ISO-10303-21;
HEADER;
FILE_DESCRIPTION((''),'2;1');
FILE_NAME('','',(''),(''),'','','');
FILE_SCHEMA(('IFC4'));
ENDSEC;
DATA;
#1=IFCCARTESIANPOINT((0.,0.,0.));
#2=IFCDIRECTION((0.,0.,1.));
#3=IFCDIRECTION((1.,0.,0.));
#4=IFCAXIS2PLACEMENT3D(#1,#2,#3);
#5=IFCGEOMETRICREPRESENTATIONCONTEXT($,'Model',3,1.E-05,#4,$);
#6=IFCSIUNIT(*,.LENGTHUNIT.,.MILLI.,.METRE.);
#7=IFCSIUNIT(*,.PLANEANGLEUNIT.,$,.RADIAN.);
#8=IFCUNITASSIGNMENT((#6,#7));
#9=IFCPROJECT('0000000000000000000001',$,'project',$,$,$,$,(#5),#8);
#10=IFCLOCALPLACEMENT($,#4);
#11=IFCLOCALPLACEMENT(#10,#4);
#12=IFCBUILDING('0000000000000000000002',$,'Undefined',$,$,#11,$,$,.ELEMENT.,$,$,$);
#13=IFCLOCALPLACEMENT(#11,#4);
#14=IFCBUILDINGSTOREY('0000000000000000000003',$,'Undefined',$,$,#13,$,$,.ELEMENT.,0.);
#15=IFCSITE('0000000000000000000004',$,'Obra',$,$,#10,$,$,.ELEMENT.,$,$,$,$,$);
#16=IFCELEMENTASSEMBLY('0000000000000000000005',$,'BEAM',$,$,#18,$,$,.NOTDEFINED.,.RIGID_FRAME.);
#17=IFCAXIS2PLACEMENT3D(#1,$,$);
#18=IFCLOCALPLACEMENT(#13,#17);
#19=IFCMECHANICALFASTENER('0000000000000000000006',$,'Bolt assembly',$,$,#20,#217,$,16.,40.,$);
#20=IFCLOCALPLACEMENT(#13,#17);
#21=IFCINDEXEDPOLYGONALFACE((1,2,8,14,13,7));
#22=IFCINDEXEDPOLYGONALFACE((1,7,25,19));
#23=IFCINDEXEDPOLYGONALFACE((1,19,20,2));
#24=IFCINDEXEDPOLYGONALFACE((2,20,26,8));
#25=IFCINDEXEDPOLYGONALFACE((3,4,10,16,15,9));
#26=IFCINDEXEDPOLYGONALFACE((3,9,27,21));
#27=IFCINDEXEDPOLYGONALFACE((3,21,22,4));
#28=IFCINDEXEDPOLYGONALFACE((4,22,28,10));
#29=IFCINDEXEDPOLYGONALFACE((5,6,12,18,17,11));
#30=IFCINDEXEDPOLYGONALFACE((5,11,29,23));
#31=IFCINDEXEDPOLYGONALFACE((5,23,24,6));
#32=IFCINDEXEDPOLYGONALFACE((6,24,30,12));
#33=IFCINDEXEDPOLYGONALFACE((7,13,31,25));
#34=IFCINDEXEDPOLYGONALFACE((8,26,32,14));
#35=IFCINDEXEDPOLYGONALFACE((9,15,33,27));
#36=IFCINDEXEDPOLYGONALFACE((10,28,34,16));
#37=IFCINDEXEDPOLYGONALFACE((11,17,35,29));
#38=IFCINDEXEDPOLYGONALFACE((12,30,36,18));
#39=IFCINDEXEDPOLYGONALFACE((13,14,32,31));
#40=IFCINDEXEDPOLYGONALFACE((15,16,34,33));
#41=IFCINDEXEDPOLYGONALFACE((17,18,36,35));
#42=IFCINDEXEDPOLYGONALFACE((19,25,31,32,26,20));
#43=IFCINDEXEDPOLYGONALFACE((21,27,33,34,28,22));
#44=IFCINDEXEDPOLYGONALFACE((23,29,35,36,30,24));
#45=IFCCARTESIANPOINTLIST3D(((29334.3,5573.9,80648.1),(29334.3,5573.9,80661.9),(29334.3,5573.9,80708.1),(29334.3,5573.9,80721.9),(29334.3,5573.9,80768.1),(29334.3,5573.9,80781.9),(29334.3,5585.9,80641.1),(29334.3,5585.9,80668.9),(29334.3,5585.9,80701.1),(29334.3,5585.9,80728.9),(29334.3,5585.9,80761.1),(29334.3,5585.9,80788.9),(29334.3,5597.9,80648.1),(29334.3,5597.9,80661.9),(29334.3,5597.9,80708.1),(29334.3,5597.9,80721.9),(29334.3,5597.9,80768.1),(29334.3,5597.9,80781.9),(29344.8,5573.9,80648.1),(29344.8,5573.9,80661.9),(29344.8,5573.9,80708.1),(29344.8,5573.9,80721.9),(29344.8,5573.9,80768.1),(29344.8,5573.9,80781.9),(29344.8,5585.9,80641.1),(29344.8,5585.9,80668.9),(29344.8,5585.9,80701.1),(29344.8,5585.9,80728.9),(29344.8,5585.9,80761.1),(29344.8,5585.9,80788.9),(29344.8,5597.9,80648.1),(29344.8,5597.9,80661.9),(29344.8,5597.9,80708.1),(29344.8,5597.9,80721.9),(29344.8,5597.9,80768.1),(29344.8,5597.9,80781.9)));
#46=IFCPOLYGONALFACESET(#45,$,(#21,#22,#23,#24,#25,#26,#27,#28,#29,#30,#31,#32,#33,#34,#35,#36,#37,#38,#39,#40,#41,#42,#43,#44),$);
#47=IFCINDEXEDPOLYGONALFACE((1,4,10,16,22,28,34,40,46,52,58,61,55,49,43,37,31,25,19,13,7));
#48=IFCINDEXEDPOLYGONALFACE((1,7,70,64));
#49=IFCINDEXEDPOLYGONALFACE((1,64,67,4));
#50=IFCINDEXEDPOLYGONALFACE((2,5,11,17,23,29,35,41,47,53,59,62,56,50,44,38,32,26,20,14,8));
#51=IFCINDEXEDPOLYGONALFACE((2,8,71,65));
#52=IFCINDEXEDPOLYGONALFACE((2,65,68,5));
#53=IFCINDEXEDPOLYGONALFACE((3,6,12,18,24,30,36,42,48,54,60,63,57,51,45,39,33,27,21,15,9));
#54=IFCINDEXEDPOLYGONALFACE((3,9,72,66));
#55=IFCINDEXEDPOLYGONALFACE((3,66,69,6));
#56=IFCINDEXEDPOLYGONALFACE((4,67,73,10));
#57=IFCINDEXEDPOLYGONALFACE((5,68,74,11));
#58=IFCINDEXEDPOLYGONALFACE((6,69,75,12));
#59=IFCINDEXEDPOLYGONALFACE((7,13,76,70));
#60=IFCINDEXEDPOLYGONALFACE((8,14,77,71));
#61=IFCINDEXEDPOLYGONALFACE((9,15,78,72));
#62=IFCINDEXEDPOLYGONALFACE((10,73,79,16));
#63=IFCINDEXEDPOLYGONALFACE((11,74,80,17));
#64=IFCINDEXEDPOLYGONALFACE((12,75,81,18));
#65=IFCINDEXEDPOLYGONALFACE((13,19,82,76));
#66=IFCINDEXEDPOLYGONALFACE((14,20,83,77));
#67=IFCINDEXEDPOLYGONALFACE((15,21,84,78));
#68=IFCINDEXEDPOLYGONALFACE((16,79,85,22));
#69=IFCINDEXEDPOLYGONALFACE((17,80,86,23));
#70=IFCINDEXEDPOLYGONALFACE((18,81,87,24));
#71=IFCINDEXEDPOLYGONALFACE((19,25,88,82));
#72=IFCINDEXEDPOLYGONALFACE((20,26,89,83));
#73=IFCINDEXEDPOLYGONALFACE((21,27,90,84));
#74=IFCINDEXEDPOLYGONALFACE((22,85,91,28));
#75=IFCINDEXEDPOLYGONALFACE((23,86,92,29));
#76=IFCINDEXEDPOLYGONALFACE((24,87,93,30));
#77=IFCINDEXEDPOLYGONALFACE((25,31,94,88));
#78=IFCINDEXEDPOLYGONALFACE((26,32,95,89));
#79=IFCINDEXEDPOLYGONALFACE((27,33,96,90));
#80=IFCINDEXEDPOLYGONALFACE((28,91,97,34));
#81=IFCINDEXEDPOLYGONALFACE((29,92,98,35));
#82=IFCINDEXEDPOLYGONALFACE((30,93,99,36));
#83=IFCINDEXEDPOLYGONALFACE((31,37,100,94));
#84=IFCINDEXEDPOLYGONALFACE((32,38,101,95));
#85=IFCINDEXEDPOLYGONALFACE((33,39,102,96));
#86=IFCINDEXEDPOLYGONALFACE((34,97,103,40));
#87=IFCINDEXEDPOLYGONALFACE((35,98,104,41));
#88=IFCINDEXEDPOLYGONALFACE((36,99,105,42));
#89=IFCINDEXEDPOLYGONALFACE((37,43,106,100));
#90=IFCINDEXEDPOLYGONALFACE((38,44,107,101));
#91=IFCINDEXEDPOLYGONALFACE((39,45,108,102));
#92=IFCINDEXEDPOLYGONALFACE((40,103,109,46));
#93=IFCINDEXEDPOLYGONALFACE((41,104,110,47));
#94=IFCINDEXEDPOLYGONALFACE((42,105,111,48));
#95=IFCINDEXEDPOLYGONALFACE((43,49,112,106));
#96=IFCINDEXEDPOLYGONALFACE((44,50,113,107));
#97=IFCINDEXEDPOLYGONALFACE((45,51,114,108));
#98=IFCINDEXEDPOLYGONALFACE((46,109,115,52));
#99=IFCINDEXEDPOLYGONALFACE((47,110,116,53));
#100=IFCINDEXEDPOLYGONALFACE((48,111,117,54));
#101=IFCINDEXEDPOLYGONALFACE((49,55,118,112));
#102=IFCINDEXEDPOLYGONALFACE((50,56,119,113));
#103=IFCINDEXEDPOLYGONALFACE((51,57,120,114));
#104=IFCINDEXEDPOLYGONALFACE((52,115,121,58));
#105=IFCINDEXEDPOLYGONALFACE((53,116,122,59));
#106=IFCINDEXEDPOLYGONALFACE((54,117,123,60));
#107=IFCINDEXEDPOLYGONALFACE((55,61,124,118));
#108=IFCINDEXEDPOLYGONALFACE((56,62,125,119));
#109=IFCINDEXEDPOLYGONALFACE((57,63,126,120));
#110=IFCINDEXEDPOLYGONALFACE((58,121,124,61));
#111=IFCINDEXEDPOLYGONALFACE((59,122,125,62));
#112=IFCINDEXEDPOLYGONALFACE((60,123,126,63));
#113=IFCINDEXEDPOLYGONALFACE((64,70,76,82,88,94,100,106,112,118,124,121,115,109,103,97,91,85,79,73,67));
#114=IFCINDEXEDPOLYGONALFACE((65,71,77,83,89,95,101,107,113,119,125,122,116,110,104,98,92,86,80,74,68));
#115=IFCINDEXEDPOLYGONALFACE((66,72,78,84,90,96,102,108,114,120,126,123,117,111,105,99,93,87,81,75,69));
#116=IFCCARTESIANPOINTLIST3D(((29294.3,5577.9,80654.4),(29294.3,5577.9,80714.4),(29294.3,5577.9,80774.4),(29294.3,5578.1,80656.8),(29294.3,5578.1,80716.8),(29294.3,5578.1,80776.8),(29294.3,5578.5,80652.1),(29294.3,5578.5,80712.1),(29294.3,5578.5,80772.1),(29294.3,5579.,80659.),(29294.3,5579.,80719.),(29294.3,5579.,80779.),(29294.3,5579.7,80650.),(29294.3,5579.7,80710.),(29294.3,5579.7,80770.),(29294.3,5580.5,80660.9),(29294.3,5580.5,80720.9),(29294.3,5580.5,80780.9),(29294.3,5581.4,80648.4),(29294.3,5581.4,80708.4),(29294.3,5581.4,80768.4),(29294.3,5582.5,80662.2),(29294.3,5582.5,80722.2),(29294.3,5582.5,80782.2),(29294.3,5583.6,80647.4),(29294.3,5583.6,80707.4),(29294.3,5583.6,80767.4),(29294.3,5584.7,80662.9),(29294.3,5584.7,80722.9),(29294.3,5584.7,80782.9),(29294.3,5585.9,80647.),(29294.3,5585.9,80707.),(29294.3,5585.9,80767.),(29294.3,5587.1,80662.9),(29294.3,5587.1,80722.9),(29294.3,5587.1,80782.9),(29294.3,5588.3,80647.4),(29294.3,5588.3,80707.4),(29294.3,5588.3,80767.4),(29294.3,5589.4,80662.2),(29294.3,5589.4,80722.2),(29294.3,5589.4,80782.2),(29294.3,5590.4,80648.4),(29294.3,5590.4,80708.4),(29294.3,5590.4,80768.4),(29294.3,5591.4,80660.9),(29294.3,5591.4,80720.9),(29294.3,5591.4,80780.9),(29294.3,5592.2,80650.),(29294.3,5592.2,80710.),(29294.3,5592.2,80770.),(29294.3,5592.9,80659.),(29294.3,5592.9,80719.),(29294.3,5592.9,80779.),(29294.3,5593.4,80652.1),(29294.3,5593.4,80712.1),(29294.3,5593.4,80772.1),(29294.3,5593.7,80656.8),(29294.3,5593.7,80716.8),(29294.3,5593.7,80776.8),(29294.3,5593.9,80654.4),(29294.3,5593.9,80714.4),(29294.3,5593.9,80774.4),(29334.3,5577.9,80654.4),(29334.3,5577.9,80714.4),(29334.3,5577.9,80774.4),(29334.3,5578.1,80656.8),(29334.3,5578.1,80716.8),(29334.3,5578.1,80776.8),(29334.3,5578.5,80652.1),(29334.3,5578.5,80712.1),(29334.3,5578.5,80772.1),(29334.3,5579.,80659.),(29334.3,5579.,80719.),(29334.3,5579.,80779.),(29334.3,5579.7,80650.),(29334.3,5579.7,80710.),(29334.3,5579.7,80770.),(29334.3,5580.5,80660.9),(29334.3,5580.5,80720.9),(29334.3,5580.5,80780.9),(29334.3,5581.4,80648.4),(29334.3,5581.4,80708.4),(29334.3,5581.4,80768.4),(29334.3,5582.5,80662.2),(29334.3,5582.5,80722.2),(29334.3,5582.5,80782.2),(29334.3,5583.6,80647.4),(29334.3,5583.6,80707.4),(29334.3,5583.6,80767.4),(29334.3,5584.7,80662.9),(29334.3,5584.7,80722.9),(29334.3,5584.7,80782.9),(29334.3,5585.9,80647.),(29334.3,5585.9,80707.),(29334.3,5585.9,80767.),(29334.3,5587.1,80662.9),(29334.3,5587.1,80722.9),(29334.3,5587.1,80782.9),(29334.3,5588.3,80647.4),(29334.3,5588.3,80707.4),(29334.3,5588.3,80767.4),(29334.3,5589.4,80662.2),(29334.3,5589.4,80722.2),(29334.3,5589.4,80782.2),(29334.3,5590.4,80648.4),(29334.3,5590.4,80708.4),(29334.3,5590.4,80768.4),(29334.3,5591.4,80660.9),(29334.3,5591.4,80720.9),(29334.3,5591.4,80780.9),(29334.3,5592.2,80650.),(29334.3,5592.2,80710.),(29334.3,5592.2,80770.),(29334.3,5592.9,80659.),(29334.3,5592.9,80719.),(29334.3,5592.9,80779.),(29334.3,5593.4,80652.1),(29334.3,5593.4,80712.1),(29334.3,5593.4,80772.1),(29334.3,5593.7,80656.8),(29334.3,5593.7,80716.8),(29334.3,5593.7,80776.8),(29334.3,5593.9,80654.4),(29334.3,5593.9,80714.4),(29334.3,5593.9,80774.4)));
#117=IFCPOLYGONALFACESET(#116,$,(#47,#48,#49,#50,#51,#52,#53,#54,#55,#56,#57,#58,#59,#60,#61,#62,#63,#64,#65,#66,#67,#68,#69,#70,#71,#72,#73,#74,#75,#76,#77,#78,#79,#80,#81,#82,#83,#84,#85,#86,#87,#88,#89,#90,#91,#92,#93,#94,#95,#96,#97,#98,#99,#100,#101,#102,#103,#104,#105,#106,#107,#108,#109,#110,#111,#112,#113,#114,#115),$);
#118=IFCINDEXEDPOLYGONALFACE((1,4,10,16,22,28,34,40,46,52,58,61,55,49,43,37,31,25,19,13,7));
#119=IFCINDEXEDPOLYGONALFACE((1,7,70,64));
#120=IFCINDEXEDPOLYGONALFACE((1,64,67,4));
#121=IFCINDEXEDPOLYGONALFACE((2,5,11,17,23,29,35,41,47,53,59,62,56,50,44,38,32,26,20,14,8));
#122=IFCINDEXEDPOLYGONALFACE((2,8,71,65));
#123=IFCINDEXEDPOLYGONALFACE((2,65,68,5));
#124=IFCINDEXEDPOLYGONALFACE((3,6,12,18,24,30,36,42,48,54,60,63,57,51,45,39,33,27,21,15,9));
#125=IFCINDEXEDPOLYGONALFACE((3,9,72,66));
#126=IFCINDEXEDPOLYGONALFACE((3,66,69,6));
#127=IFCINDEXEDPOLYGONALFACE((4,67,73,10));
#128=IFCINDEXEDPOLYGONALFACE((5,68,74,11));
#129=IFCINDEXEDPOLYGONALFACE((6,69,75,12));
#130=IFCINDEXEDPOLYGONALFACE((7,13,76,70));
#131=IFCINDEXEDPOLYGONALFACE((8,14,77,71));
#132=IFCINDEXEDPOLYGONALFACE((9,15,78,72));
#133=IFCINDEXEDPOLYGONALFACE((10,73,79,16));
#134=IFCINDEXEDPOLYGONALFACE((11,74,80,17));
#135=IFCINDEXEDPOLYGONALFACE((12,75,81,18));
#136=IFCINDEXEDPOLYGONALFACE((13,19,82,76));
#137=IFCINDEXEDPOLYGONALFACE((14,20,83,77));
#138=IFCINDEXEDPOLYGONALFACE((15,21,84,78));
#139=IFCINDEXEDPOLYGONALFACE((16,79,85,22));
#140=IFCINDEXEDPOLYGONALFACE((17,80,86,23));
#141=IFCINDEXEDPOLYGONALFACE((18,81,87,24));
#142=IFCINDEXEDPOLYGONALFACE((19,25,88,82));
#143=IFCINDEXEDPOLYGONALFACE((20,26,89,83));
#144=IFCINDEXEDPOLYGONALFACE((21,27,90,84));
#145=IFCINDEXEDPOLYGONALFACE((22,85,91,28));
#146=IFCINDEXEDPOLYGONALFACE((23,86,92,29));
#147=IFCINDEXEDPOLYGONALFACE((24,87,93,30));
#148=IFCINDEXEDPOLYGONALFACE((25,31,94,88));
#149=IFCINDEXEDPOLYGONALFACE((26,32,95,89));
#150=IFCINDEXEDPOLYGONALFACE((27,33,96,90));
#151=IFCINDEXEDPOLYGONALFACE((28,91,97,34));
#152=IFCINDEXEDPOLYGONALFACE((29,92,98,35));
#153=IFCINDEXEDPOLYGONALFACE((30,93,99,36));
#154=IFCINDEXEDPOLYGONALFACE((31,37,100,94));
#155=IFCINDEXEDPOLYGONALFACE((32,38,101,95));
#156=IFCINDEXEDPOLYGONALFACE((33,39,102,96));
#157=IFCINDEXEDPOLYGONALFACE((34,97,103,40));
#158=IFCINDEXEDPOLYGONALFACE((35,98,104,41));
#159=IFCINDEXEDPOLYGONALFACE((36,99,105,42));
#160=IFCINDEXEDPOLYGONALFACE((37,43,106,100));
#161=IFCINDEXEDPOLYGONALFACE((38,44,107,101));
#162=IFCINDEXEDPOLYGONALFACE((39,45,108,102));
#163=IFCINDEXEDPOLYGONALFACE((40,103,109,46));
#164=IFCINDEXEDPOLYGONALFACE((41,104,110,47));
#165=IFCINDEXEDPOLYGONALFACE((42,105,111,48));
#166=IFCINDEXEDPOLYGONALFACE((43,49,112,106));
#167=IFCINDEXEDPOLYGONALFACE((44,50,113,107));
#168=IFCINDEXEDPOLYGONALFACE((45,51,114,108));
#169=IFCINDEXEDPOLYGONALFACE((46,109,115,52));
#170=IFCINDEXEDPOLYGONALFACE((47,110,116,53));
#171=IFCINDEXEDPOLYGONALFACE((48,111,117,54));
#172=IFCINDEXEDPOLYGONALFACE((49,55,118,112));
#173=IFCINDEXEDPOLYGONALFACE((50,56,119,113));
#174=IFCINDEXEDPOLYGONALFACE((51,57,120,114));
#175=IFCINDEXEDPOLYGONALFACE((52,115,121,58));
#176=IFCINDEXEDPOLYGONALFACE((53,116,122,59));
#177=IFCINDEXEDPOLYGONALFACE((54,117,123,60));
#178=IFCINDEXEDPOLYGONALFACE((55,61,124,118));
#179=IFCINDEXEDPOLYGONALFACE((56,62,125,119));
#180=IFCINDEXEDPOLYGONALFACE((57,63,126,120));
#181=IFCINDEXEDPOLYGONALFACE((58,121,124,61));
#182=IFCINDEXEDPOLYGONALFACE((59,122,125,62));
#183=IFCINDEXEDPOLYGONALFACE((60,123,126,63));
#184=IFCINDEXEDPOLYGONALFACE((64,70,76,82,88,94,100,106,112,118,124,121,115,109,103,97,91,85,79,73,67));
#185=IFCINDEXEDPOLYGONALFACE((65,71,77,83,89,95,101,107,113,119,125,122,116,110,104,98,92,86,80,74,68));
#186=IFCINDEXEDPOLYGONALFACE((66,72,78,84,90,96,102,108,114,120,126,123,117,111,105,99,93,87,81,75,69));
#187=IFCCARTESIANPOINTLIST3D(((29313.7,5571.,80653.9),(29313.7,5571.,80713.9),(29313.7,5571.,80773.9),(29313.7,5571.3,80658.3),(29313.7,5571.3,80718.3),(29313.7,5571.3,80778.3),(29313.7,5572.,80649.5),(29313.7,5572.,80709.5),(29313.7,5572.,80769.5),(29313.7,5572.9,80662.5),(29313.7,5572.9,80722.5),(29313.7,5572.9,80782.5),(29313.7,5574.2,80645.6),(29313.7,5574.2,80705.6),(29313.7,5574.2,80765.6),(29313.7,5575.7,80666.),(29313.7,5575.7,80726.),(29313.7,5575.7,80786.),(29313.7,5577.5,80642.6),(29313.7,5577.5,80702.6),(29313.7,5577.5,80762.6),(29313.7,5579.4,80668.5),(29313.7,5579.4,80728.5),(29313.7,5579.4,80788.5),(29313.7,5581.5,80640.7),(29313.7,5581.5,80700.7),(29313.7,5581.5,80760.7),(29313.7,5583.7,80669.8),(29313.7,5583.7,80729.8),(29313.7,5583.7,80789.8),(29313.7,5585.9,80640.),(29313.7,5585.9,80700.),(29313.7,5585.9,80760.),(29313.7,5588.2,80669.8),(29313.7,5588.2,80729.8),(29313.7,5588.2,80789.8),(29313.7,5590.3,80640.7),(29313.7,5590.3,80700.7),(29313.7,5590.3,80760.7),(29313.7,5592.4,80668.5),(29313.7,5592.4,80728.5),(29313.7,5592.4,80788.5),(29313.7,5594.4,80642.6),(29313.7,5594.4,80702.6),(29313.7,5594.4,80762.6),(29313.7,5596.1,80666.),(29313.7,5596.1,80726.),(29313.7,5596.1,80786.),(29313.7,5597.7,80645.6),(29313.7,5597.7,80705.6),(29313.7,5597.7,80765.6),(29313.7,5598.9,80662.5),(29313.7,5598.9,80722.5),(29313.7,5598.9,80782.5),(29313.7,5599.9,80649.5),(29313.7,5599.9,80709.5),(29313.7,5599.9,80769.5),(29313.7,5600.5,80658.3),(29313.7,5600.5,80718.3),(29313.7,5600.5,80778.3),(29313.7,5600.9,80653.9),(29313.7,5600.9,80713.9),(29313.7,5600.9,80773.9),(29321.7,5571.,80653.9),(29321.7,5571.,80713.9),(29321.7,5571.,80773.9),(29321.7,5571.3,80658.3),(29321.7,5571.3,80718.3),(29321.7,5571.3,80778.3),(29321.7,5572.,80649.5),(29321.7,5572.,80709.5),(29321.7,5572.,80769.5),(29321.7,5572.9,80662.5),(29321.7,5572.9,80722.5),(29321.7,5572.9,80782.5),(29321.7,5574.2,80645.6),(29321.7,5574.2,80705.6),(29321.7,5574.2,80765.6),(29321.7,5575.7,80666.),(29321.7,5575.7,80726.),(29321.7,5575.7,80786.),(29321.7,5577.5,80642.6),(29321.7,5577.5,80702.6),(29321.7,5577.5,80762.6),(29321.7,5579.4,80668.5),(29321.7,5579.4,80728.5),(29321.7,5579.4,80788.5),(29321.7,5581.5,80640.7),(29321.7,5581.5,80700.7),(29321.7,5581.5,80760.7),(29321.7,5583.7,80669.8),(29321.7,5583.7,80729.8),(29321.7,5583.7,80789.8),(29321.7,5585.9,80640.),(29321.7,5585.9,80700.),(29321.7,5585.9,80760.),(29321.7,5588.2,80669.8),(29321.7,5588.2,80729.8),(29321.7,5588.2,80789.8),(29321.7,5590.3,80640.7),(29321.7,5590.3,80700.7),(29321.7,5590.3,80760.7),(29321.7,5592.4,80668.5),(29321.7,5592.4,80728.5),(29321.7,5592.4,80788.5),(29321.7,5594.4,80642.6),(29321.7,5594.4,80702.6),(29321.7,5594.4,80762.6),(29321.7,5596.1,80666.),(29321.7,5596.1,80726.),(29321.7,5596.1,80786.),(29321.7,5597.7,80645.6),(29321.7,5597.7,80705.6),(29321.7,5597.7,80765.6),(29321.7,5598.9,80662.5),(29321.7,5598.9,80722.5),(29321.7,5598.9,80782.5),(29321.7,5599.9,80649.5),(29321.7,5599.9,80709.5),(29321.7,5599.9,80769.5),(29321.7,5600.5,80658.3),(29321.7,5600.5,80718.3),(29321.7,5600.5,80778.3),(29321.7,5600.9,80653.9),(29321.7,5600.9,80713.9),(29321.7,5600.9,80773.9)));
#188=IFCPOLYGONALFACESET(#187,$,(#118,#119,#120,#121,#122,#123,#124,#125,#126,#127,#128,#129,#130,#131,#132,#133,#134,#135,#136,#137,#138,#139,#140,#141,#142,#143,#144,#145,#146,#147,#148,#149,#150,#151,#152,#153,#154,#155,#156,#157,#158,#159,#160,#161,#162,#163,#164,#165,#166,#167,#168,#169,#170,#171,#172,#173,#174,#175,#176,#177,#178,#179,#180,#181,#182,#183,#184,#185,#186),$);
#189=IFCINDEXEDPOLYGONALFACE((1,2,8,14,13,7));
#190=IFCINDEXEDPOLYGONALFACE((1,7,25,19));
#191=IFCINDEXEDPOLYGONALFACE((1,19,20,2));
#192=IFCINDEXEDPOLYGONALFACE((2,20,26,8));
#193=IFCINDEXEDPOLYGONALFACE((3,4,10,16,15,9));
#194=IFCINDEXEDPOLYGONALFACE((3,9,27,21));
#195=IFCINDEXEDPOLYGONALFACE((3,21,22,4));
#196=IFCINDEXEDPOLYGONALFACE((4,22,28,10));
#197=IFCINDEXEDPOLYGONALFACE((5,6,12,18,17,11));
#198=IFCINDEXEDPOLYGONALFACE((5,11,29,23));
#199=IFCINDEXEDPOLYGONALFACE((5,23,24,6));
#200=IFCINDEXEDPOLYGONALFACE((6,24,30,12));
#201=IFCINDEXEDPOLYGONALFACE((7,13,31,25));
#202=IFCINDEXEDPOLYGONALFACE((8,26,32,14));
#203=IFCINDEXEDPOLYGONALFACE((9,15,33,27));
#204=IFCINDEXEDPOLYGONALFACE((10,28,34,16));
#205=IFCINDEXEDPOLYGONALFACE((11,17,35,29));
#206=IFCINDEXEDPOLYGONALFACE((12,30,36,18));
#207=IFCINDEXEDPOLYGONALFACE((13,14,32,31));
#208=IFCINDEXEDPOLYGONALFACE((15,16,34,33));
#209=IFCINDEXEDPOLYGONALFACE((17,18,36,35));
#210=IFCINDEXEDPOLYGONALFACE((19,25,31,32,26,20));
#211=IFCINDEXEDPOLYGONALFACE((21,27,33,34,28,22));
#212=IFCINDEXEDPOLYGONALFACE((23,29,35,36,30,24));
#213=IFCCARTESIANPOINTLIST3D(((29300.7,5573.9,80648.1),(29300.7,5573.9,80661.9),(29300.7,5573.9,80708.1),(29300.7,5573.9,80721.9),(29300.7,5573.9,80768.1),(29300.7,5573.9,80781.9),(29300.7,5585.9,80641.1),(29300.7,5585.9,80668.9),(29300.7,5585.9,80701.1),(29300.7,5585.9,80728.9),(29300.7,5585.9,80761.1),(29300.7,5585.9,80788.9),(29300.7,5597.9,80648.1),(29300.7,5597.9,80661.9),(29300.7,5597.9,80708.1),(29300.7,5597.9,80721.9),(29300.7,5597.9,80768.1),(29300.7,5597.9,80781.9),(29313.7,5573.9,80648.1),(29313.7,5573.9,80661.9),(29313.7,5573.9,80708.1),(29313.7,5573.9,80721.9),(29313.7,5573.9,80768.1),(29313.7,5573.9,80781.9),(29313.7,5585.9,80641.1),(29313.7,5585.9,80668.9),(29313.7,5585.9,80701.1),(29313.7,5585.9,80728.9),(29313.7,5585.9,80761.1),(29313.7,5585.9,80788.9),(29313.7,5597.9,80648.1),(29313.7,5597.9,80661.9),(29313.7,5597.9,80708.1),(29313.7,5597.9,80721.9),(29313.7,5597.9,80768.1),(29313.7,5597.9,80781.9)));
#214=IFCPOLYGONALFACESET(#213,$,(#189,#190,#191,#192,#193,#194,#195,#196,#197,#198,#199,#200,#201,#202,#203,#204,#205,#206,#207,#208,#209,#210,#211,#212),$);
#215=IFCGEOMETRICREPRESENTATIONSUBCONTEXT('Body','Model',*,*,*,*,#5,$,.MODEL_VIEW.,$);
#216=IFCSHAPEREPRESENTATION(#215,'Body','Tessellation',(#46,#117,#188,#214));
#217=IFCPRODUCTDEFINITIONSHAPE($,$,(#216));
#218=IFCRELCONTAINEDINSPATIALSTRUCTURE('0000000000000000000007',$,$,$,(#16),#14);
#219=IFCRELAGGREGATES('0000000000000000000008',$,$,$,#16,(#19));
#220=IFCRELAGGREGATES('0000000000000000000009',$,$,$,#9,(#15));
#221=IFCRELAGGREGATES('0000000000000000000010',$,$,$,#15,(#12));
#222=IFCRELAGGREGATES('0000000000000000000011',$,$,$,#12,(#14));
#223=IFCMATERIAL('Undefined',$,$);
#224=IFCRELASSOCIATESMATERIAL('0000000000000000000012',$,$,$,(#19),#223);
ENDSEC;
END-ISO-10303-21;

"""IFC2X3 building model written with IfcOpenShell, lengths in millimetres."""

from ifc_helpers import new_model, si_unit, frame, origin_with_axes, origin_2d_with_axis, place, context, subcontext, project, spatial, polyline, circle, outline, extrude, source, transform, mapped, material, element, aggregate, save


model = new_model("IFC2X3")

# Units and contexts
model_context = context("Model", 3, precision=1e-05, world=origin_with_axes())
body_context = subcontext(model_context, "Body", "Model", "MODEL_VIEW")
ifc_project = project(units=[si_unit("LENGTHUNIT", "METRE", prefix="MILLI"), si_unit("PLANEANGLEUNIT", "RADIAN")], contexts=[model_context])

# Site, building, storey
site_placement = place(None, origin_with_axes())
site = spatial("IfcSite", under=ifc_project, at=site_placement, Name="Obra", CompositionType="ELEMENT")
building_placement = place(site_placement, origin_with_axes())
building = spatial("IfcBuilding", under=site, at=building_placement, Name="Undefined", CompositionType="ELEMENT")
storey_placement = place(building_placement, origin_with_axes())
storey = spatial("IfcBuildingStorey", under=building, at=storey_placement, Name="Undefined", CompositionType="ELEMENT", Elevation=0.0)

# Shared definitions
ifc_material_1 = material(Name="Undefined")

# Element assembly, mechanical fastener
shared_shape_1 = source(origin_with_axes(), body_context, "Body", "SweptSolid", [
    extrude(outline(polyline([(13.9, 0.0), (6.9, 12.0), (-6.9, 12.0), (-13.9, 0.0), (-6.9, -12.0), (6.9, -12.0), (13.9, 0.0)])), frame((0.0, -19.9, 0.0), z_axis=(0.0, 1.0, 0.0), x_axis=(1.0, 0.0, 0.0)), (0.0, 0.0, 1.0), 10.6),
    extrude(circle(Radius=8.0, at=origin_2d_with_axis()), frame((0.0, -9.3, 0.0), z_axis=(0.0, 1.0, 0.0), x_axis=(1.0, 0.0, 0.0)), (0.0, 0.0, 1.0), 40.0),
    extrude(circle(Radius=15.0, at=origin_2d_with_axis()), frame((0.0, 3.3, 0.0), z_axis=(0.0, 1.0, 0.0), x_axis=(1.0, 0.0, 0.0)), (0.0, 0.0, 1.0), 8.0),
    extrude(outline(polyline([(13.9, 0.0), (6.9, 12.0), (-6.9, 12.0), (-13.9, 0.0), (-6.9, -12.0), (6.9, -12.0), (13.9, 0.0)])), frame((0.0, 11.3, 0.0), z_axis=(0.0, 1.0, 0.0), x_axis=(1.0, 0.0, 0.0)), (0.0, 0.0, 1.0), 13.0),
])
assembly_1_placement = place(storey_placement, origin_with_axes())
assembly_1 = element("IfcElementAssembly", 1, at=assembly_1_placement, inside=storey, Name="BEAM", AssemblyPlace="NOTDEFINED", PredefinedType="RIGID_FRAME")
mechanical_fastener_1_placement = place(assembly_1_placement, frame((29325.0, 5535.9, 80850.0), z_axis=(-0.000001, 1.0, 0.0), x_axis=(0.0, 0.0, -1.0)))
mechanical_fastener_1 = element("IfcMechanicalFastener", 2, at=mechanical_fastener_1_placement, material=ifc_material_1, Name="Bolt assembly", NominalDiameter=16.0, NominalLength=40.0, context=body_context, shape_type="MappedRepresentation", body=[
    mapped(shared_shape_1, transform((75.0, 0.0, 50.0))),
    mapped(shared_shape_1, transform((135.0, 0.0, 50.0))),
    mapped(shared_shape_1, transform((195.0, 0.0, 50.0))),
])
aggregate(assembly_1, [mechanical_fastener_1])

save(model, "model.ifc")
